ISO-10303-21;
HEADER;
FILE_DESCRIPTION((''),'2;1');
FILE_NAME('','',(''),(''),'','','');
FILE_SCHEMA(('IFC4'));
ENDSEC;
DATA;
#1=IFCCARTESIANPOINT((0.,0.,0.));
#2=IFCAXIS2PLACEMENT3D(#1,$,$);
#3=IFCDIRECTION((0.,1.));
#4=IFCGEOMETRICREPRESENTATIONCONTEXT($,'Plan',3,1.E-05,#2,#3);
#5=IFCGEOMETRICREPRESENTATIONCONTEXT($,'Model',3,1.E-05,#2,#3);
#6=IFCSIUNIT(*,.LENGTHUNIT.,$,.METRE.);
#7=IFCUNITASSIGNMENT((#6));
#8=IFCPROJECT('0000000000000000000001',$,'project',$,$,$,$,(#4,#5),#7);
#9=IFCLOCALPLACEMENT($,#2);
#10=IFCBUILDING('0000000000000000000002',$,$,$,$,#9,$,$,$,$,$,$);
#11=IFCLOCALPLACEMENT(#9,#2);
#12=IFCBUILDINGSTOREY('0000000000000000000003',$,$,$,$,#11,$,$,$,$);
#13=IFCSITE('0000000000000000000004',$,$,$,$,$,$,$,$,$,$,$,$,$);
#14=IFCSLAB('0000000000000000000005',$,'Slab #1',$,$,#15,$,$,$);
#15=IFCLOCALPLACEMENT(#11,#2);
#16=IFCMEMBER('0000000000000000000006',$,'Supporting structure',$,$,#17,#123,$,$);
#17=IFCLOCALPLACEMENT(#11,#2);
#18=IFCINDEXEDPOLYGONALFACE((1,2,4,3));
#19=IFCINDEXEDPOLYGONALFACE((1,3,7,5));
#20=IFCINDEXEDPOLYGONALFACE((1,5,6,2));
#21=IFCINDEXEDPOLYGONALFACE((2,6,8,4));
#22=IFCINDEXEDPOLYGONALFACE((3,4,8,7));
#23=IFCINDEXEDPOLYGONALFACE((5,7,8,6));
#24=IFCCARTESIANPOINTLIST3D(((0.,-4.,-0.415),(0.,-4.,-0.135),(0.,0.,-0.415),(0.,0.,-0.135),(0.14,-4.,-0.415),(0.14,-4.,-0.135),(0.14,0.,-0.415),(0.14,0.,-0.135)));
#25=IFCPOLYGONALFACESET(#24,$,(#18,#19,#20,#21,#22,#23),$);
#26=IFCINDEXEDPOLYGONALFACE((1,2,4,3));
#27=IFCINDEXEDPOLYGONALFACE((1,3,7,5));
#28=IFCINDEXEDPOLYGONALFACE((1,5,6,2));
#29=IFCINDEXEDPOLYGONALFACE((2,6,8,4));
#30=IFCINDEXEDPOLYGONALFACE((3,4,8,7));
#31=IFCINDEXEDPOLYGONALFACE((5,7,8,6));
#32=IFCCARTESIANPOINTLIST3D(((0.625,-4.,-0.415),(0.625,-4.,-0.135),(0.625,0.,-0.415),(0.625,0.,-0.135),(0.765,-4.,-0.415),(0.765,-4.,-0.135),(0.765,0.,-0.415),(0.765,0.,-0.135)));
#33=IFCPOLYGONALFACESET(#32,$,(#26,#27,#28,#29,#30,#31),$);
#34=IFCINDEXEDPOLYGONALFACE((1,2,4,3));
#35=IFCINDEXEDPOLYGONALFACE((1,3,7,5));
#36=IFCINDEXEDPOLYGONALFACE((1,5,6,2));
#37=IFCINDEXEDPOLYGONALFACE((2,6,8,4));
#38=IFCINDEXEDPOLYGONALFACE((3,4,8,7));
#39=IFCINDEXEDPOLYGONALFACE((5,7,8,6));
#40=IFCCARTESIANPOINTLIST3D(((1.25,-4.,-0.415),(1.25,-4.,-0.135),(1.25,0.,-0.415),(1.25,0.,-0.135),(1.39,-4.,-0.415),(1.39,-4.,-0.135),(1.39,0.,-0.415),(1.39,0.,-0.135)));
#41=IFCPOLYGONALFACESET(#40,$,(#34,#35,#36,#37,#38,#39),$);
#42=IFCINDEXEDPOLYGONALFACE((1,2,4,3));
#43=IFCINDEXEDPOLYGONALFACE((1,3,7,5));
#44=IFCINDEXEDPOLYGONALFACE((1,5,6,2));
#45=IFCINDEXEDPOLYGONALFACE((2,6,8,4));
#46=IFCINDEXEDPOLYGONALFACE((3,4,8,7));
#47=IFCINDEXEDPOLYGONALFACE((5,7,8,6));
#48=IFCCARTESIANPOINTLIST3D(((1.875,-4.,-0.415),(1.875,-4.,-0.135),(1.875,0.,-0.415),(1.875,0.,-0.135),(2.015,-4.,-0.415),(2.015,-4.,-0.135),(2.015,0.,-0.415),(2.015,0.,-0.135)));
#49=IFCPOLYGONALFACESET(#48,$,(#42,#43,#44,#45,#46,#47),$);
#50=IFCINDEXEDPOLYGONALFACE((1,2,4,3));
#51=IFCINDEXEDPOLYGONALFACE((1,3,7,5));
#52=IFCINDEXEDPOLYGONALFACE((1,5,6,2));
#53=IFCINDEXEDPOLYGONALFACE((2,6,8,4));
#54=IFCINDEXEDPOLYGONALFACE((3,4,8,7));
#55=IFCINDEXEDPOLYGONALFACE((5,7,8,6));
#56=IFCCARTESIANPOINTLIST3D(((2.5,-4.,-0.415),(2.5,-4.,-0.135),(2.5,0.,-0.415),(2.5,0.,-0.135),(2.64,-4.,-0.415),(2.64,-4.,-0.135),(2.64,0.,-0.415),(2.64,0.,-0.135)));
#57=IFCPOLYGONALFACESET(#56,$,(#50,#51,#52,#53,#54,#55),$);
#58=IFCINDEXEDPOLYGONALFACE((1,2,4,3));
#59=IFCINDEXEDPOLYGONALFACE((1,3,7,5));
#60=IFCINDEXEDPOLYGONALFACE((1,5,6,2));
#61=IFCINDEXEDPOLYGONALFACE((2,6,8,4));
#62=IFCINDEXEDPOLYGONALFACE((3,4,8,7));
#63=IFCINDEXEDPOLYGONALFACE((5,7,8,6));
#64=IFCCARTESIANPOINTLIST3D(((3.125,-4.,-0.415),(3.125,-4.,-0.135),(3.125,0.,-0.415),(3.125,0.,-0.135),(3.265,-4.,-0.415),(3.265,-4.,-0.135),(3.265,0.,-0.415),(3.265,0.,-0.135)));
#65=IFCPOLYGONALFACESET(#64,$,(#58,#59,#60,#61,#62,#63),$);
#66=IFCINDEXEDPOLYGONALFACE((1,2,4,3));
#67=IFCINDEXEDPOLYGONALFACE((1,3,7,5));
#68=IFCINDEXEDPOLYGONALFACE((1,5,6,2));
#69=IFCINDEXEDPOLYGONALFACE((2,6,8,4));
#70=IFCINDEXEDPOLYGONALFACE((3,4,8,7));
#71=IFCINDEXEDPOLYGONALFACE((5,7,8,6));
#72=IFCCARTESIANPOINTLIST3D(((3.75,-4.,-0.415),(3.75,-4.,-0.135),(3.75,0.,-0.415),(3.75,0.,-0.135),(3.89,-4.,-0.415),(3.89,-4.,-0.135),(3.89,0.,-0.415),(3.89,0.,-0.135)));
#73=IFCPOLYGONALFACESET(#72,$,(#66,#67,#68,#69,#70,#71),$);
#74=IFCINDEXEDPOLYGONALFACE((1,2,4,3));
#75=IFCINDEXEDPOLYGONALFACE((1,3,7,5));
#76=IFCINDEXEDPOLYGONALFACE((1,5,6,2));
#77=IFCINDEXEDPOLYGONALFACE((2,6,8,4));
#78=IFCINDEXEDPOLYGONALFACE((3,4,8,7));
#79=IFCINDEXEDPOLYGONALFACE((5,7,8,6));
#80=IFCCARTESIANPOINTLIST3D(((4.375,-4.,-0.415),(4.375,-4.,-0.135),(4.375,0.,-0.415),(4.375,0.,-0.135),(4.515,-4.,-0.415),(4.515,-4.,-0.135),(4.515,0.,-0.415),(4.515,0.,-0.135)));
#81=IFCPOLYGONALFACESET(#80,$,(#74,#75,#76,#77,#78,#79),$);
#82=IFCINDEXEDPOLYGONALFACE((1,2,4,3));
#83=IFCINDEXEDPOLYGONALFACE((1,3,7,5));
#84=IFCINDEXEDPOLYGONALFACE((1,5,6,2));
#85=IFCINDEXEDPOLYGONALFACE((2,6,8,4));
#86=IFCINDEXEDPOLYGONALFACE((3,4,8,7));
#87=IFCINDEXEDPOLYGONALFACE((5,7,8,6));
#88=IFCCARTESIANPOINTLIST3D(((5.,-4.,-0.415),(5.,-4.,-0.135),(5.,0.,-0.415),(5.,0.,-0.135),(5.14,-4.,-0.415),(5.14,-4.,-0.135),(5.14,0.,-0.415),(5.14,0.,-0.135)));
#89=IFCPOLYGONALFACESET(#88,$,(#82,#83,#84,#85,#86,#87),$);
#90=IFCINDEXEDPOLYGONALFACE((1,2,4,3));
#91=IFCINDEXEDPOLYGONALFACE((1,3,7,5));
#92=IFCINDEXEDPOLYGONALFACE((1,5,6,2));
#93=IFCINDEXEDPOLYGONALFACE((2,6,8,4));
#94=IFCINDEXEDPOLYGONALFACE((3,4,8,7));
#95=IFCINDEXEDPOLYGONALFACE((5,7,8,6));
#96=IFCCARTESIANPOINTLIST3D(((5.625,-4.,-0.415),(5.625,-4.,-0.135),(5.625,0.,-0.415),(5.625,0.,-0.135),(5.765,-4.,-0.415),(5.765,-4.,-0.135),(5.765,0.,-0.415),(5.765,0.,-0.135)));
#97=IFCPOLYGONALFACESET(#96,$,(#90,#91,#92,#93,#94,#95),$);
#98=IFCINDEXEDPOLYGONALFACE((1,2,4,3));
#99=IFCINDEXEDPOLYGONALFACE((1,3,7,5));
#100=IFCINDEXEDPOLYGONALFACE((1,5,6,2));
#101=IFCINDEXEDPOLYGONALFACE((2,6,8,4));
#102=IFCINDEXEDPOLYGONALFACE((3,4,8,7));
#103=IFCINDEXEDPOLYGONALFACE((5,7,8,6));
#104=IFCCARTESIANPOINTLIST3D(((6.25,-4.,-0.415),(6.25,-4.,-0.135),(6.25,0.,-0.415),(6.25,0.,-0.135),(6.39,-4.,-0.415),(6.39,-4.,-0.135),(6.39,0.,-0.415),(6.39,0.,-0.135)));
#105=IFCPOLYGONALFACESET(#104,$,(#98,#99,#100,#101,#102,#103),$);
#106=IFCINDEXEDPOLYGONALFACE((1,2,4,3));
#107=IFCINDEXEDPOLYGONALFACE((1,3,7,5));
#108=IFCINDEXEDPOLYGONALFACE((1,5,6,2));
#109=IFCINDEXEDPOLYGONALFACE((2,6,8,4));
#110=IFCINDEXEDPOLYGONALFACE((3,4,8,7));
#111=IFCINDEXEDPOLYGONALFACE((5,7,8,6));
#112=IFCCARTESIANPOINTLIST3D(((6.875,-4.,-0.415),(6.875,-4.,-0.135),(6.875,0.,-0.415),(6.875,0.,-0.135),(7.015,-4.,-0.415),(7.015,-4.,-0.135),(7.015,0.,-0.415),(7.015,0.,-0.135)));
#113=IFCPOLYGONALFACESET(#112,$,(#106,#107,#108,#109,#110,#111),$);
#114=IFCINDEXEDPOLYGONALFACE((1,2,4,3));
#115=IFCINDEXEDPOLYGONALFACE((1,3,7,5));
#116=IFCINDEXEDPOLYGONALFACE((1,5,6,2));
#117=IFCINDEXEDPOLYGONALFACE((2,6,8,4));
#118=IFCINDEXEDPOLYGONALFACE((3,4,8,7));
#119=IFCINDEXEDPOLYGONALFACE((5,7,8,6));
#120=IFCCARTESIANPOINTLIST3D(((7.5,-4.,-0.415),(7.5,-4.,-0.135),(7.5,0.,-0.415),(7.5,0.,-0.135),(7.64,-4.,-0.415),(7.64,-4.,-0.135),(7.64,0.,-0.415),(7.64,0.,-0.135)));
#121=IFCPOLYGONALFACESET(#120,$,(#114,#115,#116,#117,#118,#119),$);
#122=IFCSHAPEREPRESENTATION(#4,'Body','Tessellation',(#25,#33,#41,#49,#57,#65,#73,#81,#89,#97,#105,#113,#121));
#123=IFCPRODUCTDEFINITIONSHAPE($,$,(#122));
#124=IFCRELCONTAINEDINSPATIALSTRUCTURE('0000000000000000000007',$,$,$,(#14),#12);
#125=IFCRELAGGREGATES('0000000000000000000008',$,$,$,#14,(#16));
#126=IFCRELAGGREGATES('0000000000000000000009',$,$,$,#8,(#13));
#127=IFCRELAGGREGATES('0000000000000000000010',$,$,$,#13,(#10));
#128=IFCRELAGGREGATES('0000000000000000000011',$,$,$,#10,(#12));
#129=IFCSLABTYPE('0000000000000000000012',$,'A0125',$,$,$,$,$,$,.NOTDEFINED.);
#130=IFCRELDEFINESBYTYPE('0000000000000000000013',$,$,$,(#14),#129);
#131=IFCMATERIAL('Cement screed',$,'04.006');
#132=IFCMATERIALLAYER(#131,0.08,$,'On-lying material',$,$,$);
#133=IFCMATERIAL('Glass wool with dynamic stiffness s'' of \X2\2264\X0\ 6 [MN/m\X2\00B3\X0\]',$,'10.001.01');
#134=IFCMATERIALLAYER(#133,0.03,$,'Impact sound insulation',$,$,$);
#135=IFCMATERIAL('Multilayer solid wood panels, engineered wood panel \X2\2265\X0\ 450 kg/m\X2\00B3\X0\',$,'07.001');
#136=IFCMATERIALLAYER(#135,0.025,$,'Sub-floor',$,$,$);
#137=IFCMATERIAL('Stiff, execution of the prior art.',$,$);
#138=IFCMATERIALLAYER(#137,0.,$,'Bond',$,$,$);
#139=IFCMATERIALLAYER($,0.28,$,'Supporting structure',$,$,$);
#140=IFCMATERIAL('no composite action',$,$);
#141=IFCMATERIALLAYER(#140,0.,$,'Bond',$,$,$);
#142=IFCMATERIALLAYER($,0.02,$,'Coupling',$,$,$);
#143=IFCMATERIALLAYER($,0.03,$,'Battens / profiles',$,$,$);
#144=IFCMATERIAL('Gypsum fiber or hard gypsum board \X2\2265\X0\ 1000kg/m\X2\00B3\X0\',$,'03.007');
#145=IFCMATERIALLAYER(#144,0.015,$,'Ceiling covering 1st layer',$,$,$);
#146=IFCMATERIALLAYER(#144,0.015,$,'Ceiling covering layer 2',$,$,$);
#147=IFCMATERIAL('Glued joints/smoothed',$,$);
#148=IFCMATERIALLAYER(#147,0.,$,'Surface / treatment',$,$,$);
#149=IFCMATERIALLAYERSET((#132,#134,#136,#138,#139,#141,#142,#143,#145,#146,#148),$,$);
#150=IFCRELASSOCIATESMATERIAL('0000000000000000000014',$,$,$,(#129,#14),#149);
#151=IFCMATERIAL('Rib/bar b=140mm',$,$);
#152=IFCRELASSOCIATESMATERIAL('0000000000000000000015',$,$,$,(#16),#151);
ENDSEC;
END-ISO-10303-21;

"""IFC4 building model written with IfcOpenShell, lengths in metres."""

from ifc_helpers import new_model, si_unit, direction, frame, frame_2d, origin, place, context, project, spatial, rectangle, extrude, material, layer, layer_set, type_object, element, aggregate, save


model = new_model("IFC4")

# Units and contexts
plan_context = context("Plan", 3, precision=1e-05, world=origin(), true_north=direction((0.0, 1.0)))
model_context = context("Model", 3, precision=1e-05, world=origin(), true_north=direction((0.0, 1.0)))
ifc_project = project(units=[si_unit("LENGTHUNIT", "METRE")], contexts=[plan_context, model_context])

# Site, building, storey
site = spatial("IfcSite", under=ifc_project)
building_placement = place(None, origin())
building = spatial("IfcBuilding", under=site, at=building_placement)
storey_placement = place(building_placement, origin())
storey = spatial("IfcBuildingStorey", under=building, at=storey_placement)

# Slab, member
ifc_material_1 = material(Name="Cement screed", Category="04.006")
ifc_layer_1 = layer(ifc_material_1, 0.08, Name="On-lying material")
ifc_material_2 = material(Name="Glass wool with dynamic stiffness s' of ≤ 6 [MN/m³]", Category="10.001.01")
ifc_layer_2 = layer(ifc_material_2, 0.03, Name="Impact sound insulation")
ifc_material_3 = material(Name="Multilayer solid wood panels, engineered wood panel ≥ 450 kg/m³", Category="07.001")
ifc_layer_3 = layer(ifc_material_3, 0.025, Name="Sub-floor")
ifc_material_4 = material(Name="Stiff, execution of the prior art.")
ifc_layer_4 = layer(ifc_material_4, 0.0, Name="Bond")
ifc_layer_5 = layer(None, 0.28, Name="Supporting structure")
ifc_material_5 = material(Name="no composite action")
ifc_layer_6 = layer(ifc_material_5, 0.0, Name="Bond")
ifc_layer_7 = layer(None, 0.02, Name="Coupling")
ifc_layer_8 = layer(None, 0.03, Name="Battens / profiles")
ifc_material_6 = material(Name="Gypsum fiber or hard gypsum board ≥ 1000kg/m³", Category="03.007")
ifc_layer_9 = layer(ifc_material_6, 0.015, Name="Ceiling covering 1st layer")
ifc_layer_10 = layer(ifc_material_6, 0.015, Name="Ceiling covering layer 2")
ifc_material_7 = material(Name="Glued joints/smoothed")
ifc_layer_11 = layer(ifc_material_7, 0.0, Name="Surface / treatment")
ifc_layer_set = layer_set([ifc_layer_1, ifc_layer_2, ifc_layer_3, ifc_layer_4, ifc_layer_5, ifc_layer_6, ifc_layer_7, ifc_layer_8, ifc_layer_9, ifc_layer_10, ifc_layer_11])
slab_type = type_object("IfcSlabType", Name="A0125", PredefinedType="NOTDEFINED", material=ifc_layer_set)
slab_placement = place(None, frame((0.0, 0.0, 0.0), z_axis=(0.0, 0.0, -1.0), x_axis=(1.0, 0.0, 0.0)))
slab = element("IfcSlab", 1, at=slab_placement, inside=storey, type_object=slab_type, material=ifc_layer_set, Name="Slab #1")
ifc_material_8 = material(Name="Rib/bar b=140mm")
member_1_placement = place(slab_placement, origin())
member_1 = element("IfcMember", 2, at=member_1_placement, material=ifc_material_8, Name="Supporting structure", context=plan_context, shape_type="SweptSolid", body=[
    extrude(rectangle(XDim=0.14, YDim=0.28, at=frame_2d((0.07, 0.14), x_axis=(1.0, 0.0))), frame((0.0, 4.0, 0.135), z_axis=(0.0, -1.0, 0.0), x_axis=(1.0, 0.0, 0.0)), (0.0, 0.0, 1.0), 4.0),
    extrude(rectangle(XDim=0.14, YDim=0.28, at=frame_2d((0.07, 0.14), x_axis=(1.0, 0.0))), frame((0.625, 4.0, 0.135), z_axis=(0.0, -1.0, 0.0), x_axis=(1.0, 0.0, 0.0)), (0.0, 0.0, 1.0), 4.0),
    extrude(rectangle(XDim=0.14, YDim=0.28, at=frame_2d((0.07, 0.14), x_axis=(1.0, 0.0))), frame((1.25, 4.0, 0.135), z_axis=(0.0, -1.0, 0.0), x_axis=(1.0, 0.0, 0.0)), (0.0, 0.0, 1.0), 4.0),
    extrude(rectangle(XDim=0.14, YDim=0.28, at=frame_2d((0.07, 0.14), x_axis=(1.0, 0.0))), frame((1.875, 4.0, 0.135), z_axis=(0.0, -1.0, 0.0), x_axis=(1.0, 0.0, 0.0)), (0.0, 0.0, 1.0), 4.0),
    extrude(rectangle(XDim=0.14, YDim=0.28, at=frame_2d((0.07, 0.14), x_axis=(1.0, 0.0))), frame((2.5, 4.0, 0.135), z_axis=(0.0, -1.0, 0.0), x_axis=(1.0, 0.0, 0.0)), (0.0, 0.0, 1.0), 4.0),
    extrude(rectangle(XDim=0.14, YDim=0.28, at=frame_2d((0.07, 0.14), x_axis=(1.0, 0.0))), frame((3.125, 4.0, 0.135), z_axis=(0.0, -1.0, 0.0), x_axis=(1.0, 0.0, 0.0)), (0.0, 0.0, 1.0), 4.0),
    extrude(rectangle(XDim=0.14, YDim=0.28, at=frame_2d((0.07, 0.14), x_axis=(1.0, 0.0))), frame((3.75, 4.0, 0.135), z_axis=(0.0, -1.0, 0.0), x_axis=(1.0, 0.0, 0.0)), (0.0, 0.0, 1.0), 4.0),
    extrude(rectangle(XDim=0.14, YDim=0.28, at=frame_2d((0.07, 0.14), x_axis=(1.0, 0.0))), frame((4.375, 4.0, 0.135), z_axis=(0.0, -1.0, 0.0), x_axis=(1.0, 0.0, 0.0)), (0.0, 0.0, 1.0), 4.0),
    extrude(rectangle(XDim=0.14, YDim=0.28, at=frame_2d((0.07, 0.14), x_axis=(1.0, 0.0))), frame((5.0, 4.0, 0.135), z_axis=(0.0, -1.0, 0.0), x_axis=(1.0, 0.0, 0.0)), (0.0, 0.0, 1.0), 4.0),
    extrude(rectangle(XDim=0.14, YDim=0.28, at=frame_2d((0.07, 0.14), x_axis=(1.0, 0.0))), frame((5.625, 4.0, 0.135), z_axis=(0.0, -1.0, 0.0), x_axis=(1.0, 0.0, 0.0)), (0.0, 0.0, 1.0), 4.0),
    extrude(rectangle(XDim=0.14, YDim=0.28, at=frame_2d((0.07, 0.14), x_axis=(1.0, 0.0))), frame((6.25, 4.0, 0.135), z_axis=(0.0, -1.0, 0.0), x_axis=(1.0, 0.0, 0.0)), (0.0, 0.0, 1.0), 4.0),
    extrude(rectangle(XDim=0.14, YDim=0.28, at=frame_2d((0.07, 0.14), x_axis=(1.0, 0.0))), frame((6.875, 4.0, 0.135), z_axis=(0.0, -1.0, 0.0), x_axis=(1.0, 0.0, 0.0)), (0.0, 0.0, 1.0), 4.0),
    extrude(rectangle(XDim=0.14, YDim=0.28, at=frame_2d((0.07, 0.14), x_axis=(1.0, 0.0))), frame((7.5, 4.0, 0.135), z_axis=(0.0, -1.0, 0.0), x_axis=(1.0, 0.0, 0.0)), (0.0, 0.0, 1.0), 4.0),
])
aggregate(slab, [member_1])

save(model, "model.ifc")
